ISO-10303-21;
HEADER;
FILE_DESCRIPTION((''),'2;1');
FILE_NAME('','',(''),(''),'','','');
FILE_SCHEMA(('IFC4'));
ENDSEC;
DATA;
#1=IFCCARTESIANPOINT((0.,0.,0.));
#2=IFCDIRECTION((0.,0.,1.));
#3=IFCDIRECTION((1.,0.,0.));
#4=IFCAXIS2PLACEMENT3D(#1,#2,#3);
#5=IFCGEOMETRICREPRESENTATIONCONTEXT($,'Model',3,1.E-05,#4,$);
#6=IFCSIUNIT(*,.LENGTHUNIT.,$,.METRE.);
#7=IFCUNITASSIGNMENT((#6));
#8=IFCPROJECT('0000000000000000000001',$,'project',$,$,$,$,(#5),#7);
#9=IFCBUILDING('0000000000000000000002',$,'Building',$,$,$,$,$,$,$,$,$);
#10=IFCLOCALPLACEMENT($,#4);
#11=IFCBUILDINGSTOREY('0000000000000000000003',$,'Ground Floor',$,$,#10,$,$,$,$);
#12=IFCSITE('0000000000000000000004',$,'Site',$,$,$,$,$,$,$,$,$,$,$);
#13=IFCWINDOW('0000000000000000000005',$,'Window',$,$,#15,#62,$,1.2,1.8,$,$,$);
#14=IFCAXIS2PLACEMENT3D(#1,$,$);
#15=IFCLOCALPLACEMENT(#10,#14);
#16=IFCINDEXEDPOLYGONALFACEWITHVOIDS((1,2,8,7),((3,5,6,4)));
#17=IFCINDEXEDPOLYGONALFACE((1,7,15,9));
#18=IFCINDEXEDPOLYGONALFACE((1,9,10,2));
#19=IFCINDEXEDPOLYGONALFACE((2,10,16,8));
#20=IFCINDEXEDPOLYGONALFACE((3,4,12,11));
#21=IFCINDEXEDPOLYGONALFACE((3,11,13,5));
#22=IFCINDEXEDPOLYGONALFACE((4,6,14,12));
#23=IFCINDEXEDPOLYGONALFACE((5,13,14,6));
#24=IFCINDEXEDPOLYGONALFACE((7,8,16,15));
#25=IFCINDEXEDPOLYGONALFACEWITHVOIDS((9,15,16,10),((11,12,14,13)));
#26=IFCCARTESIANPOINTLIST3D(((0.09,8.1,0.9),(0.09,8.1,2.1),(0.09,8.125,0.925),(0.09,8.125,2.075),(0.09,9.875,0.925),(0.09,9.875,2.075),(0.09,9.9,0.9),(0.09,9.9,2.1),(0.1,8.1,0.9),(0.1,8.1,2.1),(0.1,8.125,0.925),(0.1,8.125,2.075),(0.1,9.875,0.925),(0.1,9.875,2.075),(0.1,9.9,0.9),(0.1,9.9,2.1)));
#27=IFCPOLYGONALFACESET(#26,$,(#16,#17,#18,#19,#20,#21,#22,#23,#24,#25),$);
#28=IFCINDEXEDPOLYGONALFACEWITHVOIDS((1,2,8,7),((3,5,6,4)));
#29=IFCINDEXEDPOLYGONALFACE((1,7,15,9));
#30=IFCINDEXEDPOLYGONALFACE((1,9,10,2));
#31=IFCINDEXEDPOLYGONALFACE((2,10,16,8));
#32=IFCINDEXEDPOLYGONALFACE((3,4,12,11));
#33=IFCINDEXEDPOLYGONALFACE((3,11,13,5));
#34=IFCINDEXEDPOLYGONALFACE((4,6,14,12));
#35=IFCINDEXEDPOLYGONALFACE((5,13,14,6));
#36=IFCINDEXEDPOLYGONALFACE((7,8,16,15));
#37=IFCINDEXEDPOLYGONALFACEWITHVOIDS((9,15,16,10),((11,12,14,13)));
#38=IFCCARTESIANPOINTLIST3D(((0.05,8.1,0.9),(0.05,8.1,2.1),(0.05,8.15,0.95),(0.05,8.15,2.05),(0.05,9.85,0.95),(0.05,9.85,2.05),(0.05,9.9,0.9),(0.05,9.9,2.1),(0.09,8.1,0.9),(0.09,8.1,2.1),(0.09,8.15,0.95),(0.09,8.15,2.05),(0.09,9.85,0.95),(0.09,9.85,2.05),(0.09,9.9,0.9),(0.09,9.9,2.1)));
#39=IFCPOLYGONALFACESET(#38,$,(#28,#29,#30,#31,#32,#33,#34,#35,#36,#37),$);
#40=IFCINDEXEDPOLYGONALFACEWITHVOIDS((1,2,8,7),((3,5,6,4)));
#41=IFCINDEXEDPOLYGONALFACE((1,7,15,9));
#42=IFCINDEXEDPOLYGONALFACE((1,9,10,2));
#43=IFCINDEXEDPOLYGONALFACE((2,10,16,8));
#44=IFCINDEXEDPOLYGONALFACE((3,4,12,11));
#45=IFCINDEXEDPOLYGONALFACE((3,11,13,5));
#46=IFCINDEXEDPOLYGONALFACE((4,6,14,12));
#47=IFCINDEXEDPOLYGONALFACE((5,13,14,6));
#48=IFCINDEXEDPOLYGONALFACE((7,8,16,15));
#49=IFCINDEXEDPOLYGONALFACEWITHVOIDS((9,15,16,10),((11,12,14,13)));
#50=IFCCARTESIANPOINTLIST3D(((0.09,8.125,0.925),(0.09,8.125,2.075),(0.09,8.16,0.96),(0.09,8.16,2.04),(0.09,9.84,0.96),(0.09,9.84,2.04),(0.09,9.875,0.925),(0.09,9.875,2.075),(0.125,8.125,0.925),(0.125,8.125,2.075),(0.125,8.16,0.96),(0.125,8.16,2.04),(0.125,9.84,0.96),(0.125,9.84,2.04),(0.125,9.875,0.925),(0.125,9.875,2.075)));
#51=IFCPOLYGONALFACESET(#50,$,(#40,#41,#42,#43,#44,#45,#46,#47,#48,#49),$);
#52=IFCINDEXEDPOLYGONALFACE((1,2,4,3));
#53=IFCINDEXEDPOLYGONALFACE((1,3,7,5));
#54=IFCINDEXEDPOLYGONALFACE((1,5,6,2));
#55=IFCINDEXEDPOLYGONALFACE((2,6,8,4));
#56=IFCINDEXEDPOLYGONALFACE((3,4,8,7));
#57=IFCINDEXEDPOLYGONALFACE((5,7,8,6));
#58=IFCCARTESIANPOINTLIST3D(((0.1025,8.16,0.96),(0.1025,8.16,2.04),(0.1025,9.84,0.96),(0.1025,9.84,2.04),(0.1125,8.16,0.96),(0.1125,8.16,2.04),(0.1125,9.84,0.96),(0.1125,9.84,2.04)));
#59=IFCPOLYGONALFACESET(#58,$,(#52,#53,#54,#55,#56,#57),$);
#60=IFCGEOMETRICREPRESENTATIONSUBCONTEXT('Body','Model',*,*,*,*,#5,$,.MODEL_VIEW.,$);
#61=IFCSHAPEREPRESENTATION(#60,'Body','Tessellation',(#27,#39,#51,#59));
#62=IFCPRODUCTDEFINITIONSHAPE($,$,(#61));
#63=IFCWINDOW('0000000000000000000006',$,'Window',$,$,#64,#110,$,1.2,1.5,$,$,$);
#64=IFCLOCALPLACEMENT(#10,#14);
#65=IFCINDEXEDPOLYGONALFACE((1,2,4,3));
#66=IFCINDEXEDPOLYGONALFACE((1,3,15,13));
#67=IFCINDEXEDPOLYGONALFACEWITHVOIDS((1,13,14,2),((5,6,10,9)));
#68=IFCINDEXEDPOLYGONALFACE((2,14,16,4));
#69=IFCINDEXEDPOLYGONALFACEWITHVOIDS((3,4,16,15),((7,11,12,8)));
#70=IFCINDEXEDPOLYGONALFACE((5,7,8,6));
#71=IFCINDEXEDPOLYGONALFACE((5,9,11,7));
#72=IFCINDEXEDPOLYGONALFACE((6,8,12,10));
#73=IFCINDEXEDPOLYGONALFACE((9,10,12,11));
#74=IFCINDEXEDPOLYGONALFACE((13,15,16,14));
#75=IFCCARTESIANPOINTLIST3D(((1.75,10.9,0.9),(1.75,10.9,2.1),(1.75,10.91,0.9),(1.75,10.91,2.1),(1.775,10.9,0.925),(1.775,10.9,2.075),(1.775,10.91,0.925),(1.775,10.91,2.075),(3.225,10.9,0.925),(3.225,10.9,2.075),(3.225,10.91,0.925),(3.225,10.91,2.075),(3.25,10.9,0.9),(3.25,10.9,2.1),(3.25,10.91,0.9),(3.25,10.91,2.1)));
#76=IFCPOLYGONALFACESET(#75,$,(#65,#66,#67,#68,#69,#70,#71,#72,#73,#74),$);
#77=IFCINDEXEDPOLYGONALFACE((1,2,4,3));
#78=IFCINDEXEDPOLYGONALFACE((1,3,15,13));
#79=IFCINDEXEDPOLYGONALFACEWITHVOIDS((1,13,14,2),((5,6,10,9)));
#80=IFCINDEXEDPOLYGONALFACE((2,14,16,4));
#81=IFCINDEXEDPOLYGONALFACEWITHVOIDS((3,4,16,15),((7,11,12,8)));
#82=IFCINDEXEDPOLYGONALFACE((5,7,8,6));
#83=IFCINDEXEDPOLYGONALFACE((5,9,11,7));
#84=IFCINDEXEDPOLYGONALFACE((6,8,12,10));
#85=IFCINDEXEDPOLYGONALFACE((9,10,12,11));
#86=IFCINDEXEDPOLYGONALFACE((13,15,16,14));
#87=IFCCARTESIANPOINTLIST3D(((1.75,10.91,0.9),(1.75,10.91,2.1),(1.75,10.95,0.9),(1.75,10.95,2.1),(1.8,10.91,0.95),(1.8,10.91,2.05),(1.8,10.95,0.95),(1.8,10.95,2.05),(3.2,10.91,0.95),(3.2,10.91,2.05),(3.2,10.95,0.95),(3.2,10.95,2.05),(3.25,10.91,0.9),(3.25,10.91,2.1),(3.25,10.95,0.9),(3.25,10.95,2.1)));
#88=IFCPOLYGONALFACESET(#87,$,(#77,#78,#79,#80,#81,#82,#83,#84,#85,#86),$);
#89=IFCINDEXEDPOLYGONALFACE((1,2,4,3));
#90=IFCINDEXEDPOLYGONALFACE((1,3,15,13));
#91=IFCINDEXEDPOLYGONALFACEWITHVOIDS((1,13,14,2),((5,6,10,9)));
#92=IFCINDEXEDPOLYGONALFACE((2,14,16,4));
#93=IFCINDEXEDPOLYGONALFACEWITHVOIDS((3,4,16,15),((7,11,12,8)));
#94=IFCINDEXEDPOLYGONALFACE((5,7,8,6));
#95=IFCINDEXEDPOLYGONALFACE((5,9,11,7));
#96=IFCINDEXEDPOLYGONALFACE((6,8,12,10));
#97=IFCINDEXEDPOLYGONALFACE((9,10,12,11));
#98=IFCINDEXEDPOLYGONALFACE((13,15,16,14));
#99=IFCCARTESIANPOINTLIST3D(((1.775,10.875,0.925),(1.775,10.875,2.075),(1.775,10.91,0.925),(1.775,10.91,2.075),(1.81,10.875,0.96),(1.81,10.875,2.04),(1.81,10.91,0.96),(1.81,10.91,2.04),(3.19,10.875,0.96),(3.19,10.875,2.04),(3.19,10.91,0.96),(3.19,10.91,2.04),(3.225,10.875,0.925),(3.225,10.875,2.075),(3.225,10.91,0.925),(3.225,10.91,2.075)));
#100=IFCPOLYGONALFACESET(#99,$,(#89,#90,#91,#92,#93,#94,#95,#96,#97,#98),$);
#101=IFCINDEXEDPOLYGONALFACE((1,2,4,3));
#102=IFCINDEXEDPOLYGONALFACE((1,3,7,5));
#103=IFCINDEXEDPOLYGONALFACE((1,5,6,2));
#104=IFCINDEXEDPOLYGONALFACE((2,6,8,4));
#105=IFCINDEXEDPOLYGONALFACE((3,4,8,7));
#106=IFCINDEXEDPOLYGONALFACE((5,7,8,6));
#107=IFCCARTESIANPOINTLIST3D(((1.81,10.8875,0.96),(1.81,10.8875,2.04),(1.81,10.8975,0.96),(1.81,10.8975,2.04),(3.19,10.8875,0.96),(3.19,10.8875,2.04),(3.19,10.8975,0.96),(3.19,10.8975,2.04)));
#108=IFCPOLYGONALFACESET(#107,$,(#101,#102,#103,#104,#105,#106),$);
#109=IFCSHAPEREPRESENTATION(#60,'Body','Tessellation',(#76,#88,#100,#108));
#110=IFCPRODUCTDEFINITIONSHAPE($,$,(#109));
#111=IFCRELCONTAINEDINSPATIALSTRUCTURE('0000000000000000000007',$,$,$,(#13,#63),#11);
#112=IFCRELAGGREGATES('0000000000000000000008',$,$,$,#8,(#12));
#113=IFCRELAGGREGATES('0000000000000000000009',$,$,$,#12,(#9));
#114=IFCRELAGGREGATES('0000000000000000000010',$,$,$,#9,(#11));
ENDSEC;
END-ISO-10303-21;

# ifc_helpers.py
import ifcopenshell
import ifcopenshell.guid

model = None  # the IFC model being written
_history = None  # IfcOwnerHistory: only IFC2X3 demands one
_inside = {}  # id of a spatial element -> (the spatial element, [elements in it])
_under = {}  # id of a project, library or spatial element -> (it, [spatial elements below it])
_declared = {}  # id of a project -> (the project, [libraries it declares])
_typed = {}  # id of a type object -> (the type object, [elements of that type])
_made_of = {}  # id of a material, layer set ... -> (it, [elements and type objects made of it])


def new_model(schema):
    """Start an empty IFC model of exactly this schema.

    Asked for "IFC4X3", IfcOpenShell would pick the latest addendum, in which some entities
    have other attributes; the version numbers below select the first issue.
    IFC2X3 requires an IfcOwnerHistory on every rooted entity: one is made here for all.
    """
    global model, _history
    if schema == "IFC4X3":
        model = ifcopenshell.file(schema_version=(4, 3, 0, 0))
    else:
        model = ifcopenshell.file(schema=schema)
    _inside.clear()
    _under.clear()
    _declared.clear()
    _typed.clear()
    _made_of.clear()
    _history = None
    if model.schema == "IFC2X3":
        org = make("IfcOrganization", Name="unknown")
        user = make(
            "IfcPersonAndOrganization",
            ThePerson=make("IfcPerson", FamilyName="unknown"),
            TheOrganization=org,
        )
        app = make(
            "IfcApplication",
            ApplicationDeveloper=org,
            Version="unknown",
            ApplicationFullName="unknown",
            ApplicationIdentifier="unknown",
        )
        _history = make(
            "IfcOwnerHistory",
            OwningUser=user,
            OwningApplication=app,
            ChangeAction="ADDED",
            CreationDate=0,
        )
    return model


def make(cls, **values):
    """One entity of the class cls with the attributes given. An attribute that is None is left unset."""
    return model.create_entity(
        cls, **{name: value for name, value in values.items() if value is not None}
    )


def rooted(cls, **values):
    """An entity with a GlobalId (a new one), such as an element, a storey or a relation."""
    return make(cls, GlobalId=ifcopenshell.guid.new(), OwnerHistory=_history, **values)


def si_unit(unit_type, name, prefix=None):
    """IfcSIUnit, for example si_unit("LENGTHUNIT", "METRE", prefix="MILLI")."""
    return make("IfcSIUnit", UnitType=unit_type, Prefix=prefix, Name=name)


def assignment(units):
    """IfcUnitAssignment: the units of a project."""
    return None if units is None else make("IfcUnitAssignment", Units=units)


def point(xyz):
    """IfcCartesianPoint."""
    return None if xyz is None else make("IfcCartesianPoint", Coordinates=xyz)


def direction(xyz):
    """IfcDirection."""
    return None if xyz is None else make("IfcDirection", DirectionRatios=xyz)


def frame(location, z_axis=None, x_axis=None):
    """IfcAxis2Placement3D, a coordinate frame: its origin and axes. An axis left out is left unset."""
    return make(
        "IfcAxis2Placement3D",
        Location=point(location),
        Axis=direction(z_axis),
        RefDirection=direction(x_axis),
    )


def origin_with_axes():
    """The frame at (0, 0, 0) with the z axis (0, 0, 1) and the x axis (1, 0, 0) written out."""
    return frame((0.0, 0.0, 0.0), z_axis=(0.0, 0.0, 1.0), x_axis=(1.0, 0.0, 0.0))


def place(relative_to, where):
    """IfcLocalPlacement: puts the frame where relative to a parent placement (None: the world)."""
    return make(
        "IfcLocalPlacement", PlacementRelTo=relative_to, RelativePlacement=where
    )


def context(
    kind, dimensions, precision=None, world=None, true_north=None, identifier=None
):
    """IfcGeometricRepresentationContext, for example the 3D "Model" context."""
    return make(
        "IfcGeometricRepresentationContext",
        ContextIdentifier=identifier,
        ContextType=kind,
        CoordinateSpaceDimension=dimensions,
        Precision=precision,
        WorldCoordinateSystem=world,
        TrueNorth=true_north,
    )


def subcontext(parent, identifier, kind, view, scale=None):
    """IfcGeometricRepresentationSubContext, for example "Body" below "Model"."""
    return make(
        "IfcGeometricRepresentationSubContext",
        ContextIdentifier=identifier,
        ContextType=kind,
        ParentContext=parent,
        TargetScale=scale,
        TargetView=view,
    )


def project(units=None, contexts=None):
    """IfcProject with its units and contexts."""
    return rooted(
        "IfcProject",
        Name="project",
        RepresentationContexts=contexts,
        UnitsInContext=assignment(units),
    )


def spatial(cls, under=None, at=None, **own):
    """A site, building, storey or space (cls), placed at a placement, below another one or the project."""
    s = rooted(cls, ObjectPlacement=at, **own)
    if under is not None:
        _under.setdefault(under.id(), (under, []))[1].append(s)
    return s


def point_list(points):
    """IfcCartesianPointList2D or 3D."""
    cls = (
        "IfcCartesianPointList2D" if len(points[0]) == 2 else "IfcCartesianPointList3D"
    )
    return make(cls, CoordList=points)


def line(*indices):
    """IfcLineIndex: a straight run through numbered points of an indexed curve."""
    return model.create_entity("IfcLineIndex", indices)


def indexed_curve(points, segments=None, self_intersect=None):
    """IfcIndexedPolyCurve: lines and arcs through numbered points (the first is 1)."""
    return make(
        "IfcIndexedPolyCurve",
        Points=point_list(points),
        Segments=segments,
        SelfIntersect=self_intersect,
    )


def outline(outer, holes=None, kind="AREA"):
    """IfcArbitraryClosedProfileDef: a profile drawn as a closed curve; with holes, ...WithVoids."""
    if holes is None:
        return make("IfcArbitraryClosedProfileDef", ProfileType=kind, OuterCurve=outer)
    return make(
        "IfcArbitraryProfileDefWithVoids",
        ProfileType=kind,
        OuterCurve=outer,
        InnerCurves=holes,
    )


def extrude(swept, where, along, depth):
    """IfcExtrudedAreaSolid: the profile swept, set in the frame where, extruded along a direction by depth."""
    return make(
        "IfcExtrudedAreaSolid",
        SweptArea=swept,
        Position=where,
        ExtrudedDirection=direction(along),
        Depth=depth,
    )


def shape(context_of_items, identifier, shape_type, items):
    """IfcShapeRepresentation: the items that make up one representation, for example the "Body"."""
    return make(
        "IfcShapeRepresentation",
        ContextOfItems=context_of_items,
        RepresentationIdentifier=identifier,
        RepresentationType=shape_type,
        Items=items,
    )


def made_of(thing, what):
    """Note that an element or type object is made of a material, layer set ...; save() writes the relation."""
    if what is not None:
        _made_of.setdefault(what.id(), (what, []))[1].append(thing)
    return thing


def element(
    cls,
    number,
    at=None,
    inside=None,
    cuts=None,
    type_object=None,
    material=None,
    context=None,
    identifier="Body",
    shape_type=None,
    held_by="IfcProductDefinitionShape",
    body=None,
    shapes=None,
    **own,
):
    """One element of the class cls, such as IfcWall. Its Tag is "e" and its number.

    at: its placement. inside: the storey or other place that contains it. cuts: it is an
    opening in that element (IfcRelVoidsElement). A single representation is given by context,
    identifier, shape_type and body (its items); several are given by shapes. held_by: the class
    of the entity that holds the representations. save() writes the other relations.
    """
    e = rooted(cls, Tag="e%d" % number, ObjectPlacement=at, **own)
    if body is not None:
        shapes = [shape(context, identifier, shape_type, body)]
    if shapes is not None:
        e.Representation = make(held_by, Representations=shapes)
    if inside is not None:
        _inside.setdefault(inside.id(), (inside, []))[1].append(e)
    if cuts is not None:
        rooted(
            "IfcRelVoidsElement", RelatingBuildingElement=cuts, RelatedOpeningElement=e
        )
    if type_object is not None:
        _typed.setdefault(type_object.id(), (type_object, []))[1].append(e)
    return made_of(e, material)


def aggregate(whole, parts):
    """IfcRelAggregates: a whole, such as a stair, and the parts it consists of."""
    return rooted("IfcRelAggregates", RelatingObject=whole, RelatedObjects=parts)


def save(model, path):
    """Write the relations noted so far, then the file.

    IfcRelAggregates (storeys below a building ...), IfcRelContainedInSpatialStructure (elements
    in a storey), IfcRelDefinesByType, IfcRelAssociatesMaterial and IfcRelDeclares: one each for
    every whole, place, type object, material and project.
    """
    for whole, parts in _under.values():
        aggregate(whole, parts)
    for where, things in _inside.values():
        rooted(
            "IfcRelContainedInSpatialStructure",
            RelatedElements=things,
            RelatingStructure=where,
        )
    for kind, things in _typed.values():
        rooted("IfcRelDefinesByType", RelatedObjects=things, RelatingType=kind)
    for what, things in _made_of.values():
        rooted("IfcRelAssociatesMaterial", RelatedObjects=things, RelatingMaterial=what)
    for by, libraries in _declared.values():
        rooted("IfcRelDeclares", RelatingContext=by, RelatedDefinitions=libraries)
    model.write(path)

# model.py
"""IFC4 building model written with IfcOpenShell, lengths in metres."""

from ifc_helpers import new_model, si_unit, frame, origin_with_axes, place, context, subcontext, project, spatial, line, indexed_curve, outline, extrude, element, save


model = new_model("IFC4")

# Units and contexts
model_context = context("Model", 3, precision=1e-05, world=origin_with_axes())
body_context = subcontext(model_context, "Body", "Model", "MODEL_VIEW")
ifc_project = project(units=[si_unit("LENGTHUNIT", "METRE")], contexts=[model_context])

# Site, building, storey
site = spatial("IfcSite", under=ifc_project, Name="Site")
building = spatial("IfcBuilding", under=site, Name="Building")
storey_placement = place(None, origin_with_axes())
storey = spatial("IfcBuildingStorey", under=building, at=storey_placement, Name="Ground Floor")

# Windows
window_1_placement = place(storey_placement, frame((0.0, 9.9, 0.9), z_axis=(0.0, 0.0, 1.0), x_axis=(0.0, -1.0, 0.0)))
element("IfcWindow", 1, at=window_1_placement, inside=storey, Name="Window", OverallHeight=1.2, OverallWidth=1.8, context=body_context, shape_type="SweptSolid", body=[
    extrude(outline(indexed_curve([(0.0, 0.0), (1.8, 0.0), (1.8, 1.2), (0.0, 1.2)], segments=[line(1, 2, 3, 4, 1)]), holes=[indexed_curve([(0.025, 0.025), (1.775, 0.025), (1.775, 1.175), (0.025, 1.175)], segments=[line(1, 2, 3, 4, 1)])]), frame((0.0, 0.09, 0.0), z_axis=(0.0, -1.0, 0.0), x_axis=(1.0, 0.0, 0.0)), (0.0, 0.0, -1.0), 0.01),
    extrude(outline(indexed_curve([(0.0, 0.0), (1.8, 0.0), (1.8, 1.2), (0.0, 1.2)], segments=[line(1, 2, 3, 4, 1)]), holes=[indexed_curve([(0.05, 0.05), (1.75, 0.05), (1.75, 1.15), (0.05, 1.15)], segments=[line(1, 2, 3, 4, 1)])]), frame((0.0, 0.05, 0.0), z_axis=(0.0, -1.0, 0.0), x_axis=(1.0, 0.0, 0.0)), (0.0, 0.0, -1.0), 0.04),
    extrude(outline(indexed_curve([(0.0, 0.0), (1.75, 0.0), (1.75, 1.15), (0.0, 1.15)], segments=[line(1, 2, 3, 4, 1)]), holes=[indexed_curve([(0.035, 0.035), (1.715, 0.035), (1.715, 1.115), (0.035, 1.115)], segments=[line(1, 2, 3, 4, 1)])]), frame((0.025, 0.09, 0.025), z_axis=(0.0, -1.0, 0.0), x_axis=(1.0, 0.0, 0.0)), (0.0, 0.0, -1.0), 0.035),
    extrude(outline(indexed_curve([(0.035, 0.035), (1.715, 0.035), (1.715, 1.115), (0.035, 1.115)], segments=[line(1, 2, 3, 4, 1)])), frame((0.025, 0.1025, 0.025), z_axis=(0.0, -1.0, 0.0), x_axis=(1.0, 0.0, 0.0)), (0.0, 0.0, -1.0), 0.01),
])
window_2_placement = place(storey_placement, frame((3.25, 11.0, 0.9), z_axis=(0.0, 0.0, 1.0), x_axis=(-1.0, 0.0, 0.0)))
element("IfcWindow", 2, at=window_2_placement, inside=storey, Name="Window", OverallHeight=1.2, OverallWidth=1.5, context=body_context, shape_type="SweptSolid", body=[
    extrude(outline(indexed_curve([(0.0, 0.0), (1.5, 0.0), (1.5, 1.2), (0.0, 1.2)], segments=[line(1, 2, 3, 4, 1)]), holes=[indexed_curve([(0.025, 0.025), (1.475, 0.025), (1.475, 1.175), (0.025, 1.175)], segments=[line(1, 2, 3, 4, 1)])]), frame((0.0, 0.09, 0.0), z_axis=(0.0, -1.0, 0.0), x_axis=(1.0, 0.0, 0.0)), (0.0, 0.0, -1.0), 0.01),
    extrude(outline(indexed_curve([(0.0, 0.0), (1.5, 0.0), (1.5, 1.2), (0.0, 1.2)], segments=[line(1, 2, 3, 4, 1)]), holes=[indexed_curve([(0.05, 0.05), (1.45, 0.05), (1.45, 1.15), (0.05, 1.15)], segments=[line(1, 2, 3, 4, 1)])]), frame((0.0, 0.05, 0.0), z_axis=(0.0, -1.0, 0.0), x_axis=(1.0, 0.0, 0.0)), (0.0, 0.0, -1.0), 0.04),
    extrude(outline(indexed_curve([(0.0, 0.0), (1.45, 0.0), (1.45, 1.15), (0.0, 1.15)], segments=[line(1, 2, 3, 4, 1)]), holes=[indexed_curve([(0.035, 0.035), (1.415, 0.035), (1.415, 1.115), (0.035, 1.115)], segments=[line(1, 2, 3, 4, 1)])]), frame((0.025, 0.09, 0.025), z_axis=(0.0, -1.0, 0.0), x_axis=(1.0, 0.0, 0.0)), (0.0, 0.0, -1.0), 0.035),
    extrude(outline(indexed_curve([(0.035, 0.035), (1.415, 0.035), (1.415, 1.115), (0.035, 1.115)], segments=[line(1, 2, 3, 4, 1)])), frame((0.025, 0.1025, 0.025), z_axis=(0.0, -1.0, 0.0), x_axis=(1.0, 0.0, 0.0)), (0.0, 0.0, -1.0), 0.01),
])

save(model, "model.ifc")
